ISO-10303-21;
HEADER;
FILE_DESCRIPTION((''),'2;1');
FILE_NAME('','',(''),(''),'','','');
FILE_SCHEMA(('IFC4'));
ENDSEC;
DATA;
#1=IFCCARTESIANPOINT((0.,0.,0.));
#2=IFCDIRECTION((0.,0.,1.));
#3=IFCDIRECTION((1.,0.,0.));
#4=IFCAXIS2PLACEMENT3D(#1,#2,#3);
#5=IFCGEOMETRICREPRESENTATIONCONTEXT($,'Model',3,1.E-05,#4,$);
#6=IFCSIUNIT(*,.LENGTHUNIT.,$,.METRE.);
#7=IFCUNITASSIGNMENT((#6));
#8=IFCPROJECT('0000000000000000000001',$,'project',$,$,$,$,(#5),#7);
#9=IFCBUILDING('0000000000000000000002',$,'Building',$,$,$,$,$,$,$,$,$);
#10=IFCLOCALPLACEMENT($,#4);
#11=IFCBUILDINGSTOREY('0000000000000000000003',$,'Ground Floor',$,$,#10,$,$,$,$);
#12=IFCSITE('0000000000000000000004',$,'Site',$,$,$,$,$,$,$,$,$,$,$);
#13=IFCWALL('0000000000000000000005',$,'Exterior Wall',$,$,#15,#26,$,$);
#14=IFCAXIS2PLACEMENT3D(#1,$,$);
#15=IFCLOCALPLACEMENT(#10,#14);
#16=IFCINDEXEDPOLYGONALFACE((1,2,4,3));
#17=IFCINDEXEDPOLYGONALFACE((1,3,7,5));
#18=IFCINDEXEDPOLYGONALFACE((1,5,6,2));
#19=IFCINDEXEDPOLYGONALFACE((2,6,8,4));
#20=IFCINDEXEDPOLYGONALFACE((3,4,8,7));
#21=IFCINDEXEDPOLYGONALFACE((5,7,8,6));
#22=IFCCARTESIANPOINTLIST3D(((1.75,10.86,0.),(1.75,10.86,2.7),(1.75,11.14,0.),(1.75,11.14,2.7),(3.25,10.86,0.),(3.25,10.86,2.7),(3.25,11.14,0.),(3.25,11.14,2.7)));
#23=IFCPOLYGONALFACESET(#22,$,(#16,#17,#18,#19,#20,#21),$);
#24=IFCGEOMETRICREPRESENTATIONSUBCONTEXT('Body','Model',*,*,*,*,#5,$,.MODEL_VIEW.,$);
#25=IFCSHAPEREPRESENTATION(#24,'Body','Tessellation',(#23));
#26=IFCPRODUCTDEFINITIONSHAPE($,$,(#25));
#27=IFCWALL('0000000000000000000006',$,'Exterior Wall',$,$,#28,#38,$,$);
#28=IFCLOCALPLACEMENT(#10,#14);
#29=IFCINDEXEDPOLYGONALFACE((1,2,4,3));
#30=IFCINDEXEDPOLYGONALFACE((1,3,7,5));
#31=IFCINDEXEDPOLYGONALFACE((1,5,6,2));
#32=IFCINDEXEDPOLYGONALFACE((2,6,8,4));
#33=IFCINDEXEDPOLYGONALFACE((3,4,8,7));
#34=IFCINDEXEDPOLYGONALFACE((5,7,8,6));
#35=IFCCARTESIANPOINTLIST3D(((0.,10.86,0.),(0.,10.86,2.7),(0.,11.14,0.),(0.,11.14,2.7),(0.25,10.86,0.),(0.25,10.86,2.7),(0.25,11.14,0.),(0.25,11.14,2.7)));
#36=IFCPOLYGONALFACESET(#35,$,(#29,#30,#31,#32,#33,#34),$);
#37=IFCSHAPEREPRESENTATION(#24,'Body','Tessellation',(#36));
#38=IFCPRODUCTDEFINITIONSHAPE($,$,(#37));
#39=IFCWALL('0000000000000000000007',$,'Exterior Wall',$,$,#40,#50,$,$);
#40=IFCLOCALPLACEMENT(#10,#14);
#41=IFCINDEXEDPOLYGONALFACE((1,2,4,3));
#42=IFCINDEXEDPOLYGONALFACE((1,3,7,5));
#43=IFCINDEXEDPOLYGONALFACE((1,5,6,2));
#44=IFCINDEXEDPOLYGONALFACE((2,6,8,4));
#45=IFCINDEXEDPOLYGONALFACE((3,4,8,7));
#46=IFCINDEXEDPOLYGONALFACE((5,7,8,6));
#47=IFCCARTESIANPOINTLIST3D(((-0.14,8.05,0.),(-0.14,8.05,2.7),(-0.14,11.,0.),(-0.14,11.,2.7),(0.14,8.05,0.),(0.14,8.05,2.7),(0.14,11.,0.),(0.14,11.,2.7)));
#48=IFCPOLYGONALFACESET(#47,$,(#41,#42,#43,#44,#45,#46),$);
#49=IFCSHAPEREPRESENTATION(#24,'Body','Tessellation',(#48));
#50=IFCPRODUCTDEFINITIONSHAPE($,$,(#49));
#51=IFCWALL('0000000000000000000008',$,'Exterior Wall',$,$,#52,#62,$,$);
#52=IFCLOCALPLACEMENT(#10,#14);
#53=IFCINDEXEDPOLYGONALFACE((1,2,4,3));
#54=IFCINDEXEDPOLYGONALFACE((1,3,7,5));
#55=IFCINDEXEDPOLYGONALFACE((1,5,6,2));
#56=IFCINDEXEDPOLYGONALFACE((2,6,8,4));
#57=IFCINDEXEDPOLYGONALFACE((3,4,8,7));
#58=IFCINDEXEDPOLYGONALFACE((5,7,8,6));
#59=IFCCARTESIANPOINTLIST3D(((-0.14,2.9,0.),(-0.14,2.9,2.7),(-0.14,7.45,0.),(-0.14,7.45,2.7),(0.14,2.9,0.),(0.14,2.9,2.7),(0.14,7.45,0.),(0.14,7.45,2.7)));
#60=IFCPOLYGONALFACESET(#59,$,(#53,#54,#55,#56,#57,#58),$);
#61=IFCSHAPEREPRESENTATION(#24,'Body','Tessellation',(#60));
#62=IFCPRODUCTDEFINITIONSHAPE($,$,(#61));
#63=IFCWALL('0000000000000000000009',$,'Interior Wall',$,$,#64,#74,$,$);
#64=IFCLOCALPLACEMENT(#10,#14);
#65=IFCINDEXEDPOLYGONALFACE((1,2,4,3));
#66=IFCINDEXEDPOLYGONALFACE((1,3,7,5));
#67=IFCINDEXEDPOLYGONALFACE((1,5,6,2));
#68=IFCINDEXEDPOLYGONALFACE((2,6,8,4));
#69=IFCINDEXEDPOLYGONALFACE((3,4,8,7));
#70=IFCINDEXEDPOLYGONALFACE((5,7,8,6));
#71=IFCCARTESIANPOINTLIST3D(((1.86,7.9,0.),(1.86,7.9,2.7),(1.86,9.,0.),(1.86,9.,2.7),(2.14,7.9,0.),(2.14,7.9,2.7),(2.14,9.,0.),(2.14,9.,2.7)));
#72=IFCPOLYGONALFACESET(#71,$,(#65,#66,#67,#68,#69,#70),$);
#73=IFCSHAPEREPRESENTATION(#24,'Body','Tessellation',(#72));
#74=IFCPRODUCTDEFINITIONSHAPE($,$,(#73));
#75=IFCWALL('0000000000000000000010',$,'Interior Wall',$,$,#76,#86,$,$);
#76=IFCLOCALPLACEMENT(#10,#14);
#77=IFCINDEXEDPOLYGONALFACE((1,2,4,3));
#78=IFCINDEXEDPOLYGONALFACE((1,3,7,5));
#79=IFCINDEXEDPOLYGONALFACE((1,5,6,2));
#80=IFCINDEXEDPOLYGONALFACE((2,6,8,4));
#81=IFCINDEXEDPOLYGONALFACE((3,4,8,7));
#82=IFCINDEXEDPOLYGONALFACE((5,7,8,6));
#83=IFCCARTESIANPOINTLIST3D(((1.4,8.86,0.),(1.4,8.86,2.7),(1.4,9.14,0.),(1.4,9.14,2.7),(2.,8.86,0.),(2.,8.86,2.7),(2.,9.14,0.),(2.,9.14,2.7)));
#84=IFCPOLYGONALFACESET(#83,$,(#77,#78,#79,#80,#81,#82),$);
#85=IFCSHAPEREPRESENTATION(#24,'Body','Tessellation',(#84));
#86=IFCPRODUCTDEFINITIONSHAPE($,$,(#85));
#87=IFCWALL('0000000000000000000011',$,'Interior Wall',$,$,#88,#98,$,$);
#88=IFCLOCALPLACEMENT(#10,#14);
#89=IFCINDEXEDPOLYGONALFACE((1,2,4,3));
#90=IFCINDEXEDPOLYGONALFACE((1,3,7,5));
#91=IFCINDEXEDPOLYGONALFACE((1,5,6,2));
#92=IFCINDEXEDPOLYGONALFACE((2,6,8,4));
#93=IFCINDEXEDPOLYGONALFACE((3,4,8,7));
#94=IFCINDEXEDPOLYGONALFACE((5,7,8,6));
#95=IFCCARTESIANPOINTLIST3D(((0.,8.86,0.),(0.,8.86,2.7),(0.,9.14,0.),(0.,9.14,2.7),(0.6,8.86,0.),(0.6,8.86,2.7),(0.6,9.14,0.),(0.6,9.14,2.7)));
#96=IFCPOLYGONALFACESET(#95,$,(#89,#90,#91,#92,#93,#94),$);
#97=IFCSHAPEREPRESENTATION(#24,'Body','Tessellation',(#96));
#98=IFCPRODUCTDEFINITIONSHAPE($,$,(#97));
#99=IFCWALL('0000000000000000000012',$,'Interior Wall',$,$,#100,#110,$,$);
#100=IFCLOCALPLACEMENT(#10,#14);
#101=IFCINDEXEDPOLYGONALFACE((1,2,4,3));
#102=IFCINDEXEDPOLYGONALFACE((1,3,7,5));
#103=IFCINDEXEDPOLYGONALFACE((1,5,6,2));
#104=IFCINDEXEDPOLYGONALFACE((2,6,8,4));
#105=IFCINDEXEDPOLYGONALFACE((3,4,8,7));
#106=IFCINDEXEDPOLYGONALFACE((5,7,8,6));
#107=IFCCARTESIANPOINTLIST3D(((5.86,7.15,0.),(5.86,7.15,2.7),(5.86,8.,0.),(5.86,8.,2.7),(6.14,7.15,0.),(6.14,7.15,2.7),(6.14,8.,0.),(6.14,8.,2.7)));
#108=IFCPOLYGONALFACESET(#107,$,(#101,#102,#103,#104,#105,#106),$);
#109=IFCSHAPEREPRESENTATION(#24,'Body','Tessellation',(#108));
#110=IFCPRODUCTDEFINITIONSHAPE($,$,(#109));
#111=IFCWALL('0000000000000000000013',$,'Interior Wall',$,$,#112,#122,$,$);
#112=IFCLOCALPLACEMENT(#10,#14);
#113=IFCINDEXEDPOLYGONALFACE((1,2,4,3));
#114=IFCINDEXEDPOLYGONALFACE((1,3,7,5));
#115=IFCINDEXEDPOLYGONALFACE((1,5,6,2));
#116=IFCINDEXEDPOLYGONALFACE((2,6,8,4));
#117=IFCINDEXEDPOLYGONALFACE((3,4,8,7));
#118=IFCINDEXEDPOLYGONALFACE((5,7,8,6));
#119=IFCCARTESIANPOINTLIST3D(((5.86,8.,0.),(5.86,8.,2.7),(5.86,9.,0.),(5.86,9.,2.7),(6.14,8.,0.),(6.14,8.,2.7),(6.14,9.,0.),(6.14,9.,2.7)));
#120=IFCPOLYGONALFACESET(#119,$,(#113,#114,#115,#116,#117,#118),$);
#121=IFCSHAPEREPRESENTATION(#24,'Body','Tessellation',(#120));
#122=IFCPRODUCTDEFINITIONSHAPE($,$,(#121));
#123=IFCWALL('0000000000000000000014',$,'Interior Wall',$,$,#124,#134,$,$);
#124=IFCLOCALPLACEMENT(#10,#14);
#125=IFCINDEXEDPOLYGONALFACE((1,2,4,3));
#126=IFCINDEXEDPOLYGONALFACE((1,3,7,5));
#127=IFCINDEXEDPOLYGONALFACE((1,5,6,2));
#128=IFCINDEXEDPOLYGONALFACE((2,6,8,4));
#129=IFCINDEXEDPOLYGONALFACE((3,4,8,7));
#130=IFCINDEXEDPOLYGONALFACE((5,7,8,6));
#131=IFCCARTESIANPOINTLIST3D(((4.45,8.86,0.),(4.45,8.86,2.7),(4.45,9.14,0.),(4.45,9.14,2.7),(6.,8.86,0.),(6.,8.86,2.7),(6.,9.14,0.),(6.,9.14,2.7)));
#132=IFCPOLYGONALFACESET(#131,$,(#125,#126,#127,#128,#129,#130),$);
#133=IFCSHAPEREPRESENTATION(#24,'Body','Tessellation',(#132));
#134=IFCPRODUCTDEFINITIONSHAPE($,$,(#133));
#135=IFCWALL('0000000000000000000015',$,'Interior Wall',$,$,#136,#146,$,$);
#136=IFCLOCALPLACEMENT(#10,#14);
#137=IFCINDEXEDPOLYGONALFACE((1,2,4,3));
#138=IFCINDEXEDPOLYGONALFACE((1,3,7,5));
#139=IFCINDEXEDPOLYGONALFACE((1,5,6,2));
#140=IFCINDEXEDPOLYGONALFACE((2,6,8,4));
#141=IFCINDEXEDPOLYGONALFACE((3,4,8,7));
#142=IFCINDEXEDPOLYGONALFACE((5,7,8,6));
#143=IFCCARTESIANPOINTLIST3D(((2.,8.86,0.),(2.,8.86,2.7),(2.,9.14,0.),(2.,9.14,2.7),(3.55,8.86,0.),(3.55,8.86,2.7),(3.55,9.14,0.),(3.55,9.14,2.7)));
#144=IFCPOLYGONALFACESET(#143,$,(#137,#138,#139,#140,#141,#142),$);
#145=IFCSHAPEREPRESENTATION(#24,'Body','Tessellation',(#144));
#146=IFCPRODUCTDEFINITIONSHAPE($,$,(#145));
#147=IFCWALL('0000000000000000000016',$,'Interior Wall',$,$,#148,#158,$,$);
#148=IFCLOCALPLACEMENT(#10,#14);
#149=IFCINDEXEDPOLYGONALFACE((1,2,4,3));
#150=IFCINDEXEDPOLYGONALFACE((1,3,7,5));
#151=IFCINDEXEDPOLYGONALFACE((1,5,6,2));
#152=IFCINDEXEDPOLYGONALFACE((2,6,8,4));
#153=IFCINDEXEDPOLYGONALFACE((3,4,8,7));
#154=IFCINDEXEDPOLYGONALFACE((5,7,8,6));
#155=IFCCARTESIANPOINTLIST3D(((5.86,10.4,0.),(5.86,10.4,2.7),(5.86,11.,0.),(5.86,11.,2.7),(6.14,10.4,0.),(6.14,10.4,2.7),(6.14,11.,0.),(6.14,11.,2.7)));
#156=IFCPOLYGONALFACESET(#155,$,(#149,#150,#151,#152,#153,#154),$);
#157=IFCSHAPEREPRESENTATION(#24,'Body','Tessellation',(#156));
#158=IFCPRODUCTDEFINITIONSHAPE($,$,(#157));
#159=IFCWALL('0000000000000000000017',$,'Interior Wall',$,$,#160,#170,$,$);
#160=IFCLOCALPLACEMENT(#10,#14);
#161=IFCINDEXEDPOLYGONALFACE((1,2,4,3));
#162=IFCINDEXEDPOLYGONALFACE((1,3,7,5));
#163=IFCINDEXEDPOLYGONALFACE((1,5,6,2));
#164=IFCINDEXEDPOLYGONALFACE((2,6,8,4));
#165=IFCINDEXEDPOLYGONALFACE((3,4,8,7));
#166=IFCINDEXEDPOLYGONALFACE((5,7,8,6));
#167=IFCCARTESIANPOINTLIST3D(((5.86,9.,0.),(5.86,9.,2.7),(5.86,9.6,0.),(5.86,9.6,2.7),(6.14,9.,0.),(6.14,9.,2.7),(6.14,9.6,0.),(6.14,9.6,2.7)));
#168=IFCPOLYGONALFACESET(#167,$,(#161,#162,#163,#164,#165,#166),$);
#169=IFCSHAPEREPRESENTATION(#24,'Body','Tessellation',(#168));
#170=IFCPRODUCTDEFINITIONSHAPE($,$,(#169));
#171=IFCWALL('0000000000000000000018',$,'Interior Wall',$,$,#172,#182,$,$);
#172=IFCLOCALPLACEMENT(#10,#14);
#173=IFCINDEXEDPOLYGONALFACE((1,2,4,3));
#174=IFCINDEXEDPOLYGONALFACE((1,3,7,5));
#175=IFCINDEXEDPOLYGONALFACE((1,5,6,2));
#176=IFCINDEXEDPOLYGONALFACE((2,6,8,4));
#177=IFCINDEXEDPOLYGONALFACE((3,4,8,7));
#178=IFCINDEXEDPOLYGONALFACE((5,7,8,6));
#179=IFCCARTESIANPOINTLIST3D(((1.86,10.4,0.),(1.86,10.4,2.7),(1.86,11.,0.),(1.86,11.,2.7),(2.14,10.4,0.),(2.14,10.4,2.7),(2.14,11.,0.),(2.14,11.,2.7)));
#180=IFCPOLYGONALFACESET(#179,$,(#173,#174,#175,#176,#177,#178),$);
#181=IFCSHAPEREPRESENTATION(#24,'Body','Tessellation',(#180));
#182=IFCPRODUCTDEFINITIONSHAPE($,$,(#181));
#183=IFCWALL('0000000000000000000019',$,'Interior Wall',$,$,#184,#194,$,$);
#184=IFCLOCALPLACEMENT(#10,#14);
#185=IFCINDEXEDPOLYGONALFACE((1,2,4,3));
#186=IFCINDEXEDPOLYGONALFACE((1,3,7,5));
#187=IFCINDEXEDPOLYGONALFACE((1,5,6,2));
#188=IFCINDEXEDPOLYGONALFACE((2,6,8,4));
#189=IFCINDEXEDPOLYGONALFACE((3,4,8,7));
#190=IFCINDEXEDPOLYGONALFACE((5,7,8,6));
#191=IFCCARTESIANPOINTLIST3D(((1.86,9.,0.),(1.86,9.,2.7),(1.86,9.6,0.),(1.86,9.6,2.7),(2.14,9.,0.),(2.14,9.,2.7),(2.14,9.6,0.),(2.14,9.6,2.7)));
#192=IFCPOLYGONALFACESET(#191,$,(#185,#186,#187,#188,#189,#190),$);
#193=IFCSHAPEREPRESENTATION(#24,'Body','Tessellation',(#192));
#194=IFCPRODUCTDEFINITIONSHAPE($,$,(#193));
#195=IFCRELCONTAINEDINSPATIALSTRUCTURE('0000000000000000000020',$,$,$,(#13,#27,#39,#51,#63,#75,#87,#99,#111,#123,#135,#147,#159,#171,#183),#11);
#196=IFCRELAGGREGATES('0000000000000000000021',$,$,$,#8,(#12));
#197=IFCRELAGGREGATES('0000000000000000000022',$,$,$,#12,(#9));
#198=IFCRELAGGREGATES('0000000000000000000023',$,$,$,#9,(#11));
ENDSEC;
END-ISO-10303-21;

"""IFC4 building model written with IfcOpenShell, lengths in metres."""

from ifc_helpers import new_model, si_unit, frame, origin_with_axes, place, context, subcontext, project, spatial, indexed_curve, outline, extrude, element, save


model = new_model("IFC4")

# Units and contexts
model_context = context("Model", 3, precision=1e-05, world=origin_with_axes())
body_context = subcontext(model_context, "Body", "Model", "MODEL_VIEW")
ifc_project = project(units=[si_unit("LENGTHUNIT", "METRE")], contexts=[model_context])

# Site, building, storey
site = spatial("IfcSite", under=ifc_project, Name="Site")
building = spatial("IfcBuilding", under=site, Name="Building")
storey_placement = place(None, origin_with_axes())
storey = spatial("IfcBuildingStorey", under=building, at=storey_placement, Name="Ground Floor")

# Walls
wall_1_placement = place(storey_placement, frame((3.25, 11.0, 0.0), z_axis=(0.0, 0.0, 1.0), x_axis=(-1.0, 0.0, 0.0)))
element("IfcWall", 1, at=wall_1_placement, inside=storey, Name="Exterior Wall", context=body_context, shape_type="SweptSolid", body=[
    extrude(outline(indexed_curve([(0.0, 0.0), (0.0, 0.28), (1.5, 0.28), (1.5, 0.0), (0.0, 0.0)], self_intersect=False)), frame((0.0, -0.14, 0.0), z_axis=(0.0, 0.0, 1.0), x_axis=(1.0, 0.0, 0.0)), (0.0, 0.0, 1.0), 2.7),
])
wall_2_placement = place(storey_placement, frame((0.25, 11.0, 0.0), z_axis=(0.0, 0.0, 1.0), x_axis=(-1.0, 0.0, 0.0)))
element("IfcWall", 2, at=wall_2_placement, inside=storey, Name="Exterior Wall", context=body_context, shape_type="SweptSolid", body=[
    extrude(outline(indexed_curve([(0.0, 0.0), (0.0, 0.28), (0.25, 0.28), (0.25, 0.0), (0.0, 0.0)], self_intersect=False)), frame((0.0, -0.14, 0.0), z_axis=(0.0, 0.0, 1.0), x_axis=(1.0, 0.0, 0.0)), (0.0, 0.0, 1.0), 2.7),
])
wall_3_placement = place(storey_placement, frame((0.0, 11.0, 0.0), z_axis=(0.0, 0.0, 1.0), x_axis=(0.0, -1.0, 0.0)))
element("IfcWall", 3, at=wall_3_placement, inside=storey, Name="Exterior Wall", context=body_context, shape_type="SweptSolid", body=[
    extrude(outline(indexed_curve([(0.0, 0.0), (0.0, 0.28), (2.95, 0.28), (2.95, 0.0), (0.0, 0.0)], self_intersect=False)), frame((0.0, -0.14, 0.0), z_axis=(0.0, 0.0, 1.0), x_axis=(1.0, 0.0, 0.0)), (0.0, 0.0, 1.0), 2.7),
])
wall_4_placement = place(storey_placement, frame((0.0, 7.45, 0.0), z_axis=(0.0, 0.0, 1.0), x_axis=(0.0, -1.0, 0.0)))
element("IfcWall", 4, at=wall_4_placement, inside=storey, Name="Exterior Wall", context=body_context, shape_type="SweptSolid", body=[
    extrude(outline(indexed_curve([(0.0, 0.0), (0.0, 0.28), (4.55, 0.28), (4.55, 0.0), (0.0, 0.0)], self_intersect=False)), frame((0.0, -0.14, 0.0), z_axis=(0.0, 0.0, 1.0), x_axis=(1.0, 0.0, 0.0)), (0.0, 0.0, 1.0), 2.7),
])
wall_5_placement = place(storey_placement, frame((2.0, 7.9, 0.0), z_axis=(0.0, 0.0, 1.0), x_axis=(0.0, 1.0, 0.0)))
element("IfcWall", 5, at=wall_5_placement, inside=storey, Name="Interior Wall", context=body_context, shape_type="SweptSolid", body=[
    extrude(outline(indexed_curve([(0.0, 0.0), (0.0, 0.28), (1.1, 0.28), (1.1, 0.0), (0.0, 0.0)], self_intersect=False)), frame((0.0, -0.14, 0.0), z_axis=(0.0, 0.0, 1.0), x_axis=(1.0, 0.0, 0.0)), (0.0, 0.0, 1.0), 2.7),
])
for number, where, z_axis, x_axis, name in (
    (6, (2.0, 9.0, 0.0), (0.0, 0.0, 1.0), (-1.0, 0.0, 0.0), "Interior Wall"),
    (7, (0.6, 9.0, 0.0), (0.0, 0.0, 1.0), (-1.0, 0.0, 0.0), "Interior Wall"),
):
    element("IfcWall", number, at=place(storey_placement, frame(where, z_axis=z_axis, x_axis=x_axis)), inside=storey, Name=name, context=body_context, shape_type="SweptSolid", body=[
        extrude(outline(indexed_curve([(0.0, 0.0), (0.0, 0.28), (0.6, 0.28), (0.6, 0.0), (0.0, 0.0)], self_intersect=False)), frame((0.0, -0.14, 0.0), z_axis=(0.0, 0.0, 1.0), x_axis=(1.0, 0.0, 0.0)), (0.0, 0.0, 1.0), 2.7),
    ])
wall_6_placement = place(storey_placement, frame((6.0, 7.15, 0.0), z_axis=(0.0, 0.0, 1.0), x_axis=(0.0, 1.0, 0.0)))
element("IfcWall", 8, at=wall_6_placement, inside=storey, Name="Interior Wall", context=body_context, shape_type="SweptSolid", body=[
    extrude(outline(indexed_curve([(0.0, 0.0), (0.0, 0.28), (0.85, 0.28), (0.85, 0.0), (0.0, 0.0)], self_intersect=False)), frame((0.0, -0.14, 0.0), z_axis=(0.0, 0.0, 1.0), x_axis=(1.0, 0.0, 0.0)), (0.0, 0.0, 1.0), 2.7),
])
wall_7_placement = place(storey_placement, frame((6.0, 8.0, 0.0), z_axis=(0.0, 0.0, 1.0), x_axis=(0.0, 1.0, 0.0)))
element("IfcWall", 9, at=wall_7_placement, inside=storey, Name="Interior Wall", context=body_context, shape_type="SweptSolid", body=[
    extrude(outline(indexed_curve([(0.0, 0.0), (0.0, 0.28), (1.0, 0.28), (1.0, 0.0), (0.0, 0.0)], self_intersect=False)), frame((0.0, -0.14, 0.0), z_axis=(0.0, 0.0, 1.0), x_axis=(1.0, 0.0, 0.0)), (0.0, 0.0, 1.0), 2.7),
])
for number, where, z_axis, x_axis, name in (
    (10, (6.0, 9.0, 0.0), (0.0, 0.0, 1.0), (-1.0, 0.0, 0.0), "Interior Wall"),
    (11, (3.55, 9.0, 0.0), (0.0, 0.0, 1.0), (-1.0, 0.0, 0.0), "Interior Wall"),
):
    element("IfcWall", number, at=place(storey_placement, frame(where, z_axis=z_axis, x_axis=x_axis)), inside=storey, Name=name, context=body_context, shape_type="SweptSolid", body=[
        extrude(outline(indexed_curve([(0.0, 0.0), (0.0, 0.28), (1.55, 0.28), (1.55, 0.0), (0.0, 0.0)], self_intersect=False)), frame((0.0, -0.14, 0.0), z_axis=(0.0, 0.0, 1.0), x_axis=(1.0, 0.0, 0.0)), (0.0, 0.0, 1.0), 2.7),
    ])
for number, where, z_axis, x_axis, name in (
    (12, (6.0, 11.0, 0.0), (0.0, 0.0, 1.0), (0.0, -1.0, 0.0), "Interior Wall"),
    (13, (6.0, 9.6, 0.0), (0.0, 0.0, 1.0), (0.0, -1.0, 0.0), "Interior Wall"),
    (14, (2.0, 11.0, 0.0), (0.0, 0.0, 1.0), (0.0, -1.0, 0.0), "Interior Wall"),
    (15, (2.0, 9.6, 0.0), (0.0, 0.0, 1.0), (0.0, -1.0, 0.0), "Interior Wall"),
):
    element("IfcWall", number, at=place(storey_placement, frame(where, z_axis=z_axis, x_axis=x_axis)), inside=storey, Name=name, context=body_context, shape_type="SweptSolid", body=[
        extrude(outline(indexed_curve([(0.0, 0.0), (0.0, 0.28), (0.6, 0.28), (0.6, 0.0), (0.0, 0.0)], self_intersect=False)), frame((0.0, -0.14, 0.0), z_axis=(0.0, 0.0, 1.0), x_axis=(1.0, 0.0, 0.0)), (0.0, 0.0, 1.0), 2.7),
    ])

save(model, "model.ifc")
